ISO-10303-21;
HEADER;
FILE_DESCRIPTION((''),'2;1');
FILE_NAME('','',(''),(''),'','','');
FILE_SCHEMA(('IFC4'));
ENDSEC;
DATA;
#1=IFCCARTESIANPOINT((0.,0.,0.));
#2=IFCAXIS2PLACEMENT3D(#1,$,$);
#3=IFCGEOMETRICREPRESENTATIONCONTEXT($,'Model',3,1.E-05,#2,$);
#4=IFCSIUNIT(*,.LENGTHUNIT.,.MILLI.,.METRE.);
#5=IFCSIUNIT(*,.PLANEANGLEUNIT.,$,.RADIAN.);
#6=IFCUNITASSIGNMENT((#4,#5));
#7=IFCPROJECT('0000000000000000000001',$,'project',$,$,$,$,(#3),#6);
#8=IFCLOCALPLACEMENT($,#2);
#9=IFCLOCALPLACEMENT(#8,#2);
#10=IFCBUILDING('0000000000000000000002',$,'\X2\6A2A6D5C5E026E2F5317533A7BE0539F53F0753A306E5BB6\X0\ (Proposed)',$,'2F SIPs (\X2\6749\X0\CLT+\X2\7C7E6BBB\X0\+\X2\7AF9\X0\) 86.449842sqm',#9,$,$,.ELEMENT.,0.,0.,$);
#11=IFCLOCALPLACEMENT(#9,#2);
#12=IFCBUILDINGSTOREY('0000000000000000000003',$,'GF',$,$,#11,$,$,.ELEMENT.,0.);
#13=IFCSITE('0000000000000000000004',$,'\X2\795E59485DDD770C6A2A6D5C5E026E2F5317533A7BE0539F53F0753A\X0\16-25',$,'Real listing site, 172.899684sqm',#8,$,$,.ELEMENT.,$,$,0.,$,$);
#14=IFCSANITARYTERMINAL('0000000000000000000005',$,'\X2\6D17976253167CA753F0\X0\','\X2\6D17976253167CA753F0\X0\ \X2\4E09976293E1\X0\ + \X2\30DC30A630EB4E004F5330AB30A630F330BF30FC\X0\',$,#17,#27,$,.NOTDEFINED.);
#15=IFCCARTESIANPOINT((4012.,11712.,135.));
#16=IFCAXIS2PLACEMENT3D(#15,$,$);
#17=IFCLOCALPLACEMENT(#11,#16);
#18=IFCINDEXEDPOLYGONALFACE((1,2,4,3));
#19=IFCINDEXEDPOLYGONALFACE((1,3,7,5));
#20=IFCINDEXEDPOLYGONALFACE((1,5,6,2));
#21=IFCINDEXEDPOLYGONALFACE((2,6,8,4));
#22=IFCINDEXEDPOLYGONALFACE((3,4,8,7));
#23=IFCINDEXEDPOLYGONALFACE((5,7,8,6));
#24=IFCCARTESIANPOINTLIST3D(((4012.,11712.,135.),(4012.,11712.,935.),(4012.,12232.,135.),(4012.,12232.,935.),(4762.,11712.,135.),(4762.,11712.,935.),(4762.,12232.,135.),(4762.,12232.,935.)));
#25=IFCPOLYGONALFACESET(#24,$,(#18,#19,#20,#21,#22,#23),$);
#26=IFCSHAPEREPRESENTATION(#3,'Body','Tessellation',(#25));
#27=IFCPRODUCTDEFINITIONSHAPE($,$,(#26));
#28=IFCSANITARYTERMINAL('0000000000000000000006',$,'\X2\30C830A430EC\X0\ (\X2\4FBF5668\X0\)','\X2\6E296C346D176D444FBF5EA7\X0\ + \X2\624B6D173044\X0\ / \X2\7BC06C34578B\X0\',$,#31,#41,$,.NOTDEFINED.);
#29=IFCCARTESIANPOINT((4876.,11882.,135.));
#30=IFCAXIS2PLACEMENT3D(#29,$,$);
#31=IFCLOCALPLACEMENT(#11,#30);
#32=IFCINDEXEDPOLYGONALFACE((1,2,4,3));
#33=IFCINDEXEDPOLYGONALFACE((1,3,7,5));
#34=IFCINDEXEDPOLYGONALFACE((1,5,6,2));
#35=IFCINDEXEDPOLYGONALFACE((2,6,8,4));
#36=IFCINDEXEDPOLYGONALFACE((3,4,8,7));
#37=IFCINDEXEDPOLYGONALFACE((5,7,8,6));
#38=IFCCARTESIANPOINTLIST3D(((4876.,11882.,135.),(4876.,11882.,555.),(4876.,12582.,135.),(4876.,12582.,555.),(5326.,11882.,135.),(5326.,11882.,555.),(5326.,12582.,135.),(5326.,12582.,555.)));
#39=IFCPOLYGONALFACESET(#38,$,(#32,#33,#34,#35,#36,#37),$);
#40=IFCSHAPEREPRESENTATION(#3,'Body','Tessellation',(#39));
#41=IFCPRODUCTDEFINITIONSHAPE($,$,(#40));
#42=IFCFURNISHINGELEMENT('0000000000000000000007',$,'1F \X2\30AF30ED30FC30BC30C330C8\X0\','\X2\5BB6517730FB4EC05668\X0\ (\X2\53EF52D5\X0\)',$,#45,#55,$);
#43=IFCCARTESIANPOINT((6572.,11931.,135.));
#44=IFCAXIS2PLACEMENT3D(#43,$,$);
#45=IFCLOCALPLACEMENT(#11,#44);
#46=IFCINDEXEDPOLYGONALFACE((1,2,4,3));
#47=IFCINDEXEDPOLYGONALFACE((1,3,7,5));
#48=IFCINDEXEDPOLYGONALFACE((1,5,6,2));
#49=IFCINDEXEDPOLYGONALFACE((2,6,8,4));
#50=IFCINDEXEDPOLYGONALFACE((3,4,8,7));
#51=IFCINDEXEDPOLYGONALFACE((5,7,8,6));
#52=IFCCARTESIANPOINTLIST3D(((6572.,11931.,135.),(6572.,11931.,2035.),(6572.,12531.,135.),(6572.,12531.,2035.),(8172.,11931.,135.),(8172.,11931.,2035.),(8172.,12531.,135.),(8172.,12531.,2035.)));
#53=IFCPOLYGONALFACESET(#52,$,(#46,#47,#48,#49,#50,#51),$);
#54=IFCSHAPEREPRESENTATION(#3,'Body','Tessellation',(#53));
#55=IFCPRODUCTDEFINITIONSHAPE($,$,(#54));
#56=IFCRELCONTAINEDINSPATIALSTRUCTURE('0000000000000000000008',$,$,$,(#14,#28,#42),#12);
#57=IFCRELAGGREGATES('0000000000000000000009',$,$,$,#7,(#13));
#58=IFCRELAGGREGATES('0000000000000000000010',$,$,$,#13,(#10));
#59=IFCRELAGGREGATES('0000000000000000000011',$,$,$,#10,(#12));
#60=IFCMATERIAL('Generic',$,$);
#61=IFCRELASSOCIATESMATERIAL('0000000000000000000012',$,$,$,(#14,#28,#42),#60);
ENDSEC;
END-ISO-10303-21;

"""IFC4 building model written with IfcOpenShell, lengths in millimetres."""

from ifc_helpers import new_model, si_unit, frame, frame_2d, origin, place, context, project, spatial, rectangle, extrude, material, element, save


model = new_model("IFC4")

# Units and contexts
model_context = context("Model", 3, precision=1e-05, world=origin())
ifc_project = project(units=[si_unit("LENGTHUNIT", "METRE", prefix="MILLI"), si_unit("PLANEANGLEUNIT", "RADIAN")], contexts=[model_context])

# Site, building, storey
site_placement = place(None, origin())
site = spatial("IfcSite", under=ifc_project, at=site_placement, Name="神奈川県横浜市港北区篠原台町16-25", ObjectType="Real listing site, 172.899684sqm", CompositionType="ELEMENT", RefElevation=0.0)
building_placement = place(site_placement, origin())
building = spatial("IfcBuilding", under=site, at=building_placement, Name="横浜市港北区篠原台町の家 (Proposed)", ObjectType="2F SIPs (杉CLT+籾殻+竹) 86.449842sqm", CompositionType="ELEMENT", ElevationOfRefHeight=0.0, ElevationOfTerrain=0.0)
storey_placement = place(building_placement, origin())
storey = spatial("IfcBuildingStorey", under=building, at=storey_placement, Name="GF", CompositionType="ELEMENT", Elevation=0.0)

# Shared definitions
ifc_material_1 = material(Name="Generic")

# Sanitary terminals
sanitary_terminal_1_placement = place(storey_placement, frame((4012.0, 11712.0, 135.0)))
element("IfcSanitaryTerminal", 1, at=sanitary_terminal_1_placement, inside=storey, material=ifc_material_1, Name="洗面化粧台", Description="洗面化粧台 三面鏡 + ボウル一体カウンター", PredefinedType="NOTDEFINED", context=model_context, shape_type="SweptSolid", body=[
    extrude(rectangle(XDim=750.0, YDim=520.0, at=frame_2d((375.0, 260.0))), frame((4012.0, 11712.0, 135.0)), (0.0, 0.0, 1.0), 800.0),
])
sanitary_terminal_2_placement = place(storey_placement, frame((4876.0, 11882.0, 135.0)))
element("IfcSanitaryTerminal", 2, at=sanitary_terminal_2_placement, inside=storey, material=ifc_material_1, Name="トイレ (便器)", Description="温水洗浄便座 + 手洗い / 節水型", PredefinedType="NOTDEFINED", context=model_context, shape_type="SweptSolid", body=[
    extrude(rectangle(XDim=450.0, YDim=700.0, at=frame_2d((225.0, 350.0))), frame((4876.0, 11882.0, 135.0)), (0.0, 0.0, 1.0), 420.0),
])

# Furnishing element
furnishing_placement = place(storey_placement, frame((6572.0, 11931.0, 135.0)))
element("IfcFurnishingElement", 3, at=furnishing_placement, inside=storey, material=ifc_material_1, Name="1F クローゼット", Description="家具・什器 (可動)", context=model_context, shape_type="SweptSolid", body=[
    extrude(rectangle(XDim=1600.0, YDim=600.0, at=frame_2d((800.0, 300.0))), frame((6572.0, 11931.0, 135.0)), (0.0, 0.0, 1.0), 1900.0),
])

save(model, "model.ifc")
